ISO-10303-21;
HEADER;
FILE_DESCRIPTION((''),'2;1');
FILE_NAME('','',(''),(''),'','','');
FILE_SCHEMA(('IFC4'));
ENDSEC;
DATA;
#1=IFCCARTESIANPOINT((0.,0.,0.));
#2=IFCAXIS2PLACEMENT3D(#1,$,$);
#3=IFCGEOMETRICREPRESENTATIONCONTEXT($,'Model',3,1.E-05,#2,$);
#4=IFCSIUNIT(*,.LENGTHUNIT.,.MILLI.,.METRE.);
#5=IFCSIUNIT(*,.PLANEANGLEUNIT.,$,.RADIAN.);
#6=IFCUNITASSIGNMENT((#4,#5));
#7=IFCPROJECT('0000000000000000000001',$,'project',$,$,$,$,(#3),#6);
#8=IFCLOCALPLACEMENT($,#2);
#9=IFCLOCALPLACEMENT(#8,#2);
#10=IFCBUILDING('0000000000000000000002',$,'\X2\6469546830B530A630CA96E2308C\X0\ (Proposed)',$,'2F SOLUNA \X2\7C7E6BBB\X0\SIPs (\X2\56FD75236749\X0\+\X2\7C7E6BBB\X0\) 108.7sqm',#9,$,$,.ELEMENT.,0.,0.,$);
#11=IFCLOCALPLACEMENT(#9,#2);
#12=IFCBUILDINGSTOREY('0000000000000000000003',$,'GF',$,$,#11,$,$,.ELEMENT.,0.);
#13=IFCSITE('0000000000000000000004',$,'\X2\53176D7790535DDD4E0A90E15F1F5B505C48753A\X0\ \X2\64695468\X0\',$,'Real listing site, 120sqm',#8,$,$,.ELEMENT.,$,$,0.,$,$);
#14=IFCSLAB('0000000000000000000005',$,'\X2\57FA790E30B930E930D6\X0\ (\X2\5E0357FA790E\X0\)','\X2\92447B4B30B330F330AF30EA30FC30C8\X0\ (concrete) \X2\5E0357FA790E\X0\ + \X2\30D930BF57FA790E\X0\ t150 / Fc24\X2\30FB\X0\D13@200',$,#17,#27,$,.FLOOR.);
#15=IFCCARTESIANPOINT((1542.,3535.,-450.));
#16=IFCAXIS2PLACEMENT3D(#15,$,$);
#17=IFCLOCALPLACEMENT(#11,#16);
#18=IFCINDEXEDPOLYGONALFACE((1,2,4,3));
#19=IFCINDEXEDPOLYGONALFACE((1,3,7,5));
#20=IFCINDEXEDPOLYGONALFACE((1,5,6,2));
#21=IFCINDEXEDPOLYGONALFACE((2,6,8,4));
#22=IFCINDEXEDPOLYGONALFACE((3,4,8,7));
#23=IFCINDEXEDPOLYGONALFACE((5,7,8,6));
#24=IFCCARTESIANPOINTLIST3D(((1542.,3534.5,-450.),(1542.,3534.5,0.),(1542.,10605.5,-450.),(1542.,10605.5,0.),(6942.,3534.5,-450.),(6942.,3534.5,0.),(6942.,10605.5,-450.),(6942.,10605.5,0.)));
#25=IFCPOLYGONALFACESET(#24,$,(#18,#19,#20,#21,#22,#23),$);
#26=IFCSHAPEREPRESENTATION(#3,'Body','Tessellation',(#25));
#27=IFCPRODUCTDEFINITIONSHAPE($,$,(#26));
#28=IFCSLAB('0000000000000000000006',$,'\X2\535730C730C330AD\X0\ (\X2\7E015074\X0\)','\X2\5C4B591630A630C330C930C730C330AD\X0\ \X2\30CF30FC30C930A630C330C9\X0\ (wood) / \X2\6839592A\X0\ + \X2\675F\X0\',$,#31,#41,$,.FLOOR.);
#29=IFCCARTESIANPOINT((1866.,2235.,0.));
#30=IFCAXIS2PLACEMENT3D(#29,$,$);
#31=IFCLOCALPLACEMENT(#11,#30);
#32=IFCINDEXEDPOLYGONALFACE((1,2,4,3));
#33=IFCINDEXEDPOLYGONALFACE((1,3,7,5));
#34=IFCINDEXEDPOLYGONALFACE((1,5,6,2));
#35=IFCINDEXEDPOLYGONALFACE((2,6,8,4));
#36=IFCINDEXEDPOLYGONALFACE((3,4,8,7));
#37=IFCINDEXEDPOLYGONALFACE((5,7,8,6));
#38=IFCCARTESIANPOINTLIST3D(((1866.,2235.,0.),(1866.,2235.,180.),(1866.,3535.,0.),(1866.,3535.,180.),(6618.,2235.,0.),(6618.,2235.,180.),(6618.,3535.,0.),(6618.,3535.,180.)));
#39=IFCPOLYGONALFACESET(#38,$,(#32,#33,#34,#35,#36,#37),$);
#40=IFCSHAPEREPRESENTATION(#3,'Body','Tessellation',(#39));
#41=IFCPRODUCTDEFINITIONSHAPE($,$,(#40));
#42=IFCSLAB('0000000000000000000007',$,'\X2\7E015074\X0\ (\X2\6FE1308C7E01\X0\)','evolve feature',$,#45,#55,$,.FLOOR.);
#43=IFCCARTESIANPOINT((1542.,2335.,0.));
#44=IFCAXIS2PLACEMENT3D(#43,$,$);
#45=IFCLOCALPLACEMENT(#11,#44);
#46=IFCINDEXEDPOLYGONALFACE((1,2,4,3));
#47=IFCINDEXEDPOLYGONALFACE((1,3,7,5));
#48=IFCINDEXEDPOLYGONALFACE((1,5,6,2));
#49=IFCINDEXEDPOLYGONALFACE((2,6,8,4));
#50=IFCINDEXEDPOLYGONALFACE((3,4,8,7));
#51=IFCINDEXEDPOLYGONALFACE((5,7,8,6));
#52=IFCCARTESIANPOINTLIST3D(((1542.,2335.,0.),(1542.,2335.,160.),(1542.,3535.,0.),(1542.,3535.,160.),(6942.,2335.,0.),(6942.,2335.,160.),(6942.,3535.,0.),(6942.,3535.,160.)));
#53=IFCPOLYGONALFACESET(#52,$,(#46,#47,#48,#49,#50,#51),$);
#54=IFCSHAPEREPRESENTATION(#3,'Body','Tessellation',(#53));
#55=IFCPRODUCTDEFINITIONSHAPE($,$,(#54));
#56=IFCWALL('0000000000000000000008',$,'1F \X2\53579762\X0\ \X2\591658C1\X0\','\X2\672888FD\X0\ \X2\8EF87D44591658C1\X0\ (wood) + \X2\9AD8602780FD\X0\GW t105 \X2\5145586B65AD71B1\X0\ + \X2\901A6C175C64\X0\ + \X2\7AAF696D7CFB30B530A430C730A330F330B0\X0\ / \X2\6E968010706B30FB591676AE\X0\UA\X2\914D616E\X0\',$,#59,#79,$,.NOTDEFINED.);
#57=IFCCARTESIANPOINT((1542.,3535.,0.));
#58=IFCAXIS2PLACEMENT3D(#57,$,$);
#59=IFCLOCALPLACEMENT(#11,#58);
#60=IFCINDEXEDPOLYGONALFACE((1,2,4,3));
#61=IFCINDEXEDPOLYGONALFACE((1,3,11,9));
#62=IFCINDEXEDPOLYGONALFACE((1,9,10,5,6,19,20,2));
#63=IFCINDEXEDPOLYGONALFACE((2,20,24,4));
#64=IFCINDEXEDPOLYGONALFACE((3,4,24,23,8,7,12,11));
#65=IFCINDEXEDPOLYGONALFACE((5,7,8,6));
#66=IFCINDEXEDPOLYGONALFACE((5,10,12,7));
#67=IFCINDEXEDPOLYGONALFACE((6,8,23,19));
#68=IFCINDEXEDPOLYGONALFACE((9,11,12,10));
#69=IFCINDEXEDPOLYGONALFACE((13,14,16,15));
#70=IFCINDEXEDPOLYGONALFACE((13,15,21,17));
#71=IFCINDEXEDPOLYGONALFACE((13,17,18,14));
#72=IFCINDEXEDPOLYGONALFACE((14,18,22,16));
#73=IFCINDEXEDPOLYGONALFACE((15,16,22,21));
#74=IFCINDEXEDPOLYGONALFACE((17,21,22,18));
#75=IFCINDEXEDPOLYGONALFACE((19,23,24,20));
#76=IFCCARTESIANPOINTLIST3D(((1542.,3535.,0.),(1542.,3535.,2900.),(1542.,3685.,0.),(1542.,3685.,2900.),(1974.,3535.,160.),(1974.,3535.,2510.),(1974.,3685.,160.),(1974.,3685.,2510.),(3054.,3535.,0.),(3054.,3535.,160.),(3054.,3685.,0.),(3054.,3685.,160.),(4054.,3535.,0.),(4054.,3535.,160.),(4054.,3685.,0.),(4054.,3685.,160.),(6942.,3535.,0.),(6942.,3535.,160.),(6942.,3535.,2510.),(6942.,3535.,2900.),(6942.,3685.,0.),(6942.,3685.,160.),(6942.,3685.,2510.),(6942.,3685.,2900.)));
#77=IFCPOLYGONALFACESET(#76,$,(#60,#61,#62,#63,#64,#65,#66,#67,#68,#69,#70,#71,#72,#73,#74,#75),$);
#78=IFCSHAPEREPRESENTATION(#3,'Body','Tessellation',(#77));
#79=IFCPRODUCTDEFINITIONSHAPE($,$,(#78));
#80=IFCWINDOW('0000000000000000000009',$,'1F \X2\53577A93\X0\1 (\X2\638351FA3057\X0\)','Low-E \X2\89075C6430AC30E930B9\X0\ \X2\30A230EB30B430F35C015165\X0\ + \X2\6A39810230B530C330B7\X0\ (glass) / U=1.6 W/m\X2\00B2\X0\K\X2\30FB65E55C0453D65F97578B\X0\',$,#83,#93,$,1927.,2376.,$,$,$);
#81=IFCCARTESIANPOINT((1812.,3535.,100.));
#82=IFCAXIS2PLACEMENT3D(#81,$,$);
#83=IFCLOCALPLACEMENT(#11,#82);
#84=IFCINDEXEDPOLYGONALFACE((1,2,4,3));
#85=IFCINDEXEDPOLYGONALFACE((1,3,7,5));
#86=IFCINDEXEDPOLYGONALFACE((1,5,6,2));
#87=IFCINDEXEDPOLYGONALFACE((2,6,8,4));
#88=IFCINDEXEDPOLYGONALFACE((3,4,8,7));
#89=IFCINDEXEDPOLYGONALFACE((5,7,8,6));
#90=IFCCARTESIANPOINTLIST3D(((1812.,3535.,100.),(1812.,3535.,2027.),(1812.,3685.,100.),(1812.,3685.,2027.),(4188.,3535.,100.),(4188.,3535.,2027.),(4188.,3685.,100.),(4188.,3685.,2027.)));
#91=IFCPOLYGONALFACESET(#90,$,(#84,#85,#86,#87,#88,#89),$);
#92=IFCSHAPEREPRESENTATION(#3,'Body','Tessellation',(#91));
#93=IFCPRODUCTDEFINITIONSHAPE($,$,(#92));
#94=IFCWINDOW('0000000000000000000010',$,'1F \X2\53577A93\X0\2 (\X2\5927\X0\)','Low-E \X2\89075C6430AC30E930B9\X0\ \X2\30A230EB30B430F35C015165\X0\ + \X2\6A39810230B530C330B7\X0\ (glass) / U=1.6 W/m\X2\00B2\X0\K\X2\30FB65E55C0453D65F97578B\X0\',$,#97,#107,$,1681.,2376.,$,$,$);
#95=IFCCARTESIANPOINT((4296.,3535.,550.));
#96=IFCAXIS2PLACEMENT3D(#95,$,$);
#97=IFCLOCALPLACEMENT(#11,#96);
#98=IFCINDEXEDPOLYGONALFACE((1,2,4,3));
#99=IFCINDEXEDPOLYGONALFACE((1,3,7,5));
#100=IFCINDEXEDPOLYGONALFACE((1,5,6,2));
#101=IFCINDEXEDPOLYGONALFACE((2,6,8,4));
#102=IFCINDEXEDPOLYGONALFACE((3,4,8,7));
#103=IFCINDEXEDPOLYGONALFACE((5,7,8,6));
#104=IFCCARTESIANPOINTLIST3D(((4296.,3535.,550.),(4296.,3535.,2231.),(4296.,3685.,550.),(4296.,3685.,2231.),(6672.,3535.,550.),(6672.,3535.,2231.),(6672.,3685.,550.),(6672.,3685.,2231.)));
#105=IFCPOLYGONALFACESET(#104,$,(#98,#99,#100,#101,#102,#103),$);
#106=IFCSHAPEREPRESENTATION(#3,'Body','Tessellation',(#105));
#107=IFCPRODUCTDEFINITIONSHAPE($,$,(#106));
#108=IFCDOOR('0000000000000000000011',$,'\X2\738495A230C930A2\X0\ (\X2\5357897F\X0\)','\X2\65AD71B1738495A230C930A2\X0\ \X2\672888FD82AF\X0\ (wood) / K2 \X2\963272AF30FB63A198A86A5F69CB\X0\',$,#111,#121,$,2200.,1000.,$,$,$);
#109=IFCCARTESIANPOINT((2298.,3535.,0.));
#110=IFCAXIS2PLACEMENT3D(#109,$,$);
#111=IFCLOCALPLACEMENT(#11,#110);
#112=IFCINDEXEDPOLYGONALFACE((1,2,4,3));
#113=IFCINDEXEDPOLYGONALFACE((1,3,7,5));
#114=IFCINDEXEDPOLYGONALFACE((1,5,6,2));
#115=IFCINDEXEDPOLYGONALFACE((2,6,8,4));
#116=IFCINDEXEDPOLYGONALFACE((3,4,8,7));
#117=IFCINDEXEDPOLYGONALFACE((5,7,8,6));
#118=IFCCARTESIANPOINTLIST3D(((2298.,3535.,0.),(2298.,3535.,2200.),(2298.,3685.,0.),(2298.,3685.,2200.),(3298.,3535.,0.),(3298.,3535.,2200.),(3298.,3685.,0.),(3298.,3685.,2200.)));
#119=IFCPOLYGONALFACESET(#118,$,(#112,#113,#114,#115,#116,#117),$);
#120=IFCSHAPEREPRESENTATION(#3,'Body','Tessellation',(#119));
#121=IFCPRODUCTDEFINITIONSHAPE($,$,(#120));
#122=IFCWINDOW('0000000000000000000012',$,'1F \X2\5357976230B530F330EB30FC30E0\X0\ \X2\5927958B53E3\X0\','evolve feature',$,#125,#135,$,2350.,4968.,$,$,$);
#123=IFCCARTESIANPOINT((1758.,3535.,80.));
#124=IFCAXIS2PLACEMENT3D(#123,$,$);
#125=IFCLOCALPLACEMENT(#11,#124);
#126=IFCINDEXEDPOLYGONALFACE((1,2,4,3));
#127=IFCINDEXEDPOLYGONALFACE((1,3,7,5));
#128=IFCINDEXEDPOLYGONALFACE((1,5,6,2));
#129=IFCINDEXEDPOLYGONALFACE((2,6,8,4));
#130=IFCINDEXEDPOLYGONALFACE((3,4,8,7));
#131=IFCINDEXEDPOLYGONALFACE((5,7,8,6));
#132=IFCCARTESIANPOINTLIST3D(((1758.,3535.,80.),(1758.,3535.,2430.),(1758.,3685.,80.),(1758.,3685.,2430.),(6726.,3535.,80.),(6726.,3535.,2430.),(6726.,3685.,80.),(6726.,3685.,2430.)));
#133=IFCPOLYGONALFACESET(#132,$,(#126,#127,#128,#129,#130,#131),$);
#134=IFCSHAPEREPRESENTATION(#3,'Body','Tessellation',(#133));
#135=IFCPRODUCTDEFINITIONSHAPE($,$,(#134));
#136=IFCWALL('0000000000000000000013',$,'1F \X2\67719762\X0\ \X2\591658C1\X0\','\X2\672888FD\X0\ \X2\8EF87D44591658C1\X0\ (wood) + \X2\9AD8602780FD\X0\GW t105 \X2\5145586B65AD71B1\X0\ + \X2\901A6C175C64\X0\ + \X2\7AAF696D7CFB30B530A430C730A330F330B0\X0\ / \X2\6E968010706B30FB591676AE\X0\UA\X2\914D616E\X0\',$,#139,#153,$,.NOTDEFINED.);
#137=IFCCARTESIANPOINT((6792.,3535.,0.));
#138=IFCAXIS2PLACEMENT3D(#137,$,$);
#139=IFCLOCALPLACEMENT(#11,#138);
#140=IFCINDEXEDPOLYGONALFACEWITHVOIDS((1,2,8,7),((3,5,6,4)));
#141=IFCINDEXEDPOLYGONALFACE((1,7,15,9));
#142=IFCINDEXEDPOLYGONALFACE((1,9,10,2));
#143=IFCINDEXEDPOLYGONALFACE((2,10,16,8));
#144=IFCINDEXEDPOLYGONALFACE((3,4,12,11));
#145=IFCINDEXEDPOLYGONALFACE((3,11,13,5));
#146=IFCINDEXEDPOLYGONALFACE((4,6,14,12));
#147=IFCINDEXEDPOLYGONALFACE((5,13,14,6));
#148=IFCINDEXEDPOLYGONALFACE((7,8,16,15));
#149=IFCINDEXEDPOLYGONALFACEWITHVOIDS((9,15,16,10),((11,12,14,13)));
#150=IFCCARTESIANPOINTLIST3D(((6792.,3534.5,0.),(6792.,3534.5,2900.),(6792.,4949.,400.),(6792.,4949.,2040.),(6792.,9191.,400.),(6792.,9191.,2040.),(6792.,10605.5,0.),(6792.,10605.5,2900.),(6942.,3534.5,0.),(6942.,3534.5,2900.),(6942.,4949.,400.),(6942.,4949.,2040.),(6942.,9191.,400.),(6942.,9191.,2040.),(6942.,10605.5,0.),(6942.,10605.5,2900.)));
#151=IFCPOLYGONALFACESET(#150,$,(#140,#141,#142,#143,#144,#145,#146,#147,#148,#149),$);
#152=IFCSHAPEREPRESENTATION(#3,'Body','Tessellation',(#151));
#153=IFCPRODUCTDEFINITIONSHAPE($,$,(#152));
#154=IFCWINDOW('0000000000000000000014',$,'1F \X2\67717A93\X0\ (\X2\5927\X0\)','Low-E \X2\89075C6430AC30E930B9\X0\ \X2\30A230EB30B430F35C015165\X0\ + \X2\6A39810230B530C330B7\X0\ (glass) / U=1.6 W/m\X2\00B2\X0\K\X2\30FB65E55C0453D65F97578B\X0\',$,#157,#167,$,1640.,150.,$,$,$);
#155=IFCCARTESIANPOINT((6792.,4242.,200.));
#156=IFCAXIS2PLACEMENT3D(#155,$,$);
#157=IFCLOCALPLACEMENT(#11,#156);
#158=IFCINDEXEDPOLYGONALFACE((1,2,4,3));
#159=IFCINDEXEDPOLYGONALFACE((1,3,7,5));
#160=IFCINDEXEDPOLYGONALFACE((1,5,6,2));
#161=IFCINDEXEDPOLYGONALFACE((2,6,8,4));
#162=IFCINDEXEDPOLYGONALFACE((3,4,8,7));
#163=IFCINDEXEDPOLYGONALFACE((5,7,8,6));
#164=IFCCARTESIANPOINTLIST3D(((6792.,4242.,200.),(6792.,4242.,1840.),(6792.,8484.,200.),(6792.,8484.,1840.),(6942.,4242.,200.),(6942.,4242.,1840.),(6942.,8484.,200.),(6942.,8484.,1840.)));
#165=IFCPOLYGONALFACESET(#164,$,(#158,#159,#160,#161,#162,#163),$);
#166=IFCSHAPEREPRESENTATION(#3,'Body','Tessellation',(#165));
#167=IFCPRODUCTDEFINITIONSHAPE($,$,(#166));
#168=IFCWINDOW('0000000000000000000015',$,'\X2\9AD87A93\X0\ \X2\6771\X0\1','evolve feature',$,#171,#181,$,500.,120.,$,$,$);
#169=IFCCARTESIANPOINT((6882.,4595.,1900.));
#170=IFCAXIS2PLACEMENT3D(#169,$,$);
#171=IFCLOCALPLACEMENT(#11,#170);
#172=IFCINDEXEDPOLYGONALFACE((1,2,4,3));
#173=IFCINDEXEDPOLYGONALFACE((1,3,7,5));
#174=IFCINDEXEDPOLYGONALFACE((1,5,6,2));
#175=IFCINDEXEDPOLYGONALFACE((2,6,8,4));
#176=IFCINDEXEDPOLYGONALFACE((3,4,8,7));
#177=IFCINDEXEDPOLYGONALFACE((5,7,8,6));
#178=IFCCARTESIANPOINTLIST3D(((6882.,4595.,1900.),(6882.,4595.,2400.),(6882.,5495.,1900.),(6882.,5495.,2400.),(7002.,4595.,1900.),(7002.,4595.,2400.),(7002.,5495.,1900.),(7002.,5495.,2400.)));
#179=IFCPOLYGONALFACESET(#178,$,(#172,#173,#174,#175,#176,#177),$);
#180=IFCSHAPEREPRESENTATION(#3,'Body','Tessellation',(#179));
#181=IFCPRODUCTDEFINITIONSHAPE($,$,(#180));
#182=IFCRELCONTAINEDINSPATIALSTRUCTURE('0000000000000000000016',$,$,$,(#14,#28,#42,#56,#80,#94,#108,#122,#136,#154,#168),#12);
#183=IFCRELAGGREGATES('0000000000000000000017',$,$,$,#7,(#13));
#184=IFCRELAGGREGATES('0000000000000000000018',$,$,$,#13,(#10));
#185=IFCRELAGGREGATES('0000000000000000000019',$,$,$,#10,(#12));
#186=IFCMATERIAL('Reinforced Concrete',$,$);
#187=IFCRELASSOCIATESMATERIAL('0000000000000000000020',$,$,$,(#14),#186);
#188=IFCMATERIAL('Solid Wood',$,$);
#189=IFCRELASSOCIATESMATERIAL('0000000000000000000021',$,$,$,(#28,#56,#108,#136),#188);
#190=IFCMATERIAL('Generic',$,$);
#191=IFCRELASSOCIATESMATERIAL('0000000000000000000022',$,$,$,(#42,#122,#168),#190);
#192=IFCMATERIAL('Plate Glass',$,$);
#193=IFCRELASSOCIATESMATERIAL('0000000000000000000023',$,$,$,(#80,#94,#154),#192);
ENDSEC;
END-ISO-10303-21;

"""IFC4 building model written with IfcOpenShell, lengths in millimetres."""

from ifc_helpers import new_model, si_unit, frame, frame_2d, origin, place, context, project, spatial, rectangle, extrude, material, element, fill, save


model = new_model("IFC4")

# Units and contexts
model_context = context("Model", 3, precision=1e-05, world=origin())
ifc_project = project(units=[si_unit("LENGTHUNIT", "METRE", prefix="MILLI"), si_unit("PLANEANGLEUNIT", "RADIAN")], contexts=[model_context])

# Site, building, storey
site_placement = place(None, origin())
site = spatial("IfcSite", under=ifc_project, at=site_placement, Name="北海道川上郡弟子屈町 摩周", ObjectType="Real listing site, 120sqm", CompositionType="ELEMENT", RefElevation=0.0)
building_placement = place(site_placement, origin())
building = spatial("IfcBuilding", under=site, at=building_placement, Name="摩周サウナ離れ (Proposed)", ObjectType="2F SOLUNA 籾殻SIPs (国産杉+籾殻) 108.7sqm", CompositionType="ELEMENT", ElevationOfRefHeight=0.0, ElevationOfTerrain=0.0)
storey_placement = place(building_placement, origin())
storey = spatial("IfcBuildingStorey", under=building, at=storey_placement, Name="GF", CompositionType="ELEMENT", Elevation=0.0)

# Slabs
ifc_material_1 = material(Name="Reinforced Concrete")
slab_1_placement = place(storey_placement, frame((1542.0, 3535.0, -450.0)))
element("IfcSlab", 1, at=slab_1_placement, inside=storey, material=ifc_material_1, Name="基礎スラブ (布基礎)", Description="鉄筋コンクリート (concrete) 布基礎 + ベタ基礎 t150 / Fc24・D13@200", PredefinedType="FLOOR", context=model_context, shape_type="SweptSolid", body=[
    extrude(rectangle(XDim=5400.0, YDim=7071.0, at=frame_2d((2700.0, 3535.0))), frame((1542.0, 3535.0, -450.0)), (0.0, 0.0, 1.0), 450.0),
])
ifc_material_2 = material(Name="Solid Wood")
slab_2_placement = place(storey_placement, frame((1866.0, 2235.0, 0.0)))
element("IfcSlab", 2, at=slab_2_placement, inside=storey, material=ifc_material_2, Name="南デッキ (縁側)", Description="屋外ウッドデッキ ハードウッド (wood) / 根太 + 束", PredefinedType="FLOOR", context=model_context, shape_type="SweptSolid", body=[
    extrude(rectangle(XDim=4752.0, YDim=1300.0, at=frame_2d((2376.0, 650.0))), frame((1866.0, 2235.0, 0.0)), (0.0, 0.0, 1.0), 180.0),
])
ifc_material_3 = material(Name="Generic")
slab_3_placement = place(storey_placement, frame((1542.0, 2335.0, 0.0)))
element("IfcSlab", 3, at=slab_3_placement, inside=storey, material=ifc_material_3, Name="縁側 (濡れ縁)", Description="evolve feature", PredefinedType="FLOOR", context=model_context, shape_type="SweptSolid", body=[
    extrude(rectangle(XDim=5400.0, YDim=1200.0, at=frame_2d((2700.0, 600.0))), frame((1542.0, 2335.0, 0.0)), (0.0, 0.0, 1.0), 160.0),
])

# Wall, openings, windows, door
wall_1_placement = place(storey_placement, frame((1542.0, 3535.0, 0.0)))
wall_1 = element("IfcWall", 4, at=wall_1_placement, inside=storey, material=ifc_material_2, Name="1F 南面 外壁", Description="木製 軸組外壁 (wood) + 高性能GW t105 充填断熱 + 通気層 + 窯業系サイディング / 準耐火・外皮UA配慮", PredefinedType="NOTDEFINED", context=model_context, shape_type="SweptSolid", body=[
    extrude(rectangle(XDim=5400.0, YDim=150.0, at=frame_2d((2700.0, 75.0))), frame((1542.0, 3535.0, 0.0)), (0.0, 0.0, 1.0), 2900.0),
])
opening_1_placement = place(storey_placement, frame((1812.0, 3535.0, 100.0)))
opening_1 = element("IfcOpeningElement", 5, at=opening_1_placement, cuts=wall_1, PredefinedType="NOTDEFINED", context=model_context, shape_type="SweptSolid", body=[
    extrude(rectangle(XDim=2376.0, YDim=150.0, at=frame_2d((1188.0, 75.0))), frame((1812.0, 3535.0, 100.0)), (0.0, 0.0, 1.0), 1927.0),
])
opening_2_placement = place(storey_placement, frame((4296.0, 3535.0, 550.0)))
opening_2 = element("IfcOpeningElement", 6, at=opening_2_placement, cuts=wall_1, PredefinedType="NOTDEFINED", context=model_context, shape_type="SweptSolid", body=[
    extrude(rectangle(XDim=2376.0, YDim=150.0, at=frame_2d((1188.0, 75.0))), frame((4296.0, 3535.0, 550.0)), (0.0, 0.0, 1.0), 1681.0),
])
opening_3_placement = place(storey_placement, frame((2298.0, 3535.0, 0.0)))
opening_3 = element("IfcOpeningElement", 7, at=opening_3_placement, cuts=wall_1, PredefinedType="NOTDEFINED", context=model_context, shape_type="SweptSolid", body=[
    extrude(rectangle(XDim=1000.0, YDim=150.0, at=frame_2d((500.0, 75.0))), frame((2298.0, 3535.0, 0.0)), (0.0, 0.0, 1.0), 2200.0),
])
opening_4_placement = place(storey_placement, frame((1758.0, 3535.0, 80.0)))
opening_4 = element("IfcOpeningElement", 8, at=opening_4_placement, cuts=wall_1, PredefinedType="NOTDEFINED", context=model_context, shape_type="SweptSolid", body=[
    extrude(rectangle(XDim=4968.0, YDim=150.0, at=frame_2d((2484.0, 75.0))), frame((1758.0, 3535.0, 80.0)), (0.0, 0.0, 1.0), 2350.0),
])
ifc_material_4 = material(Name="Plate Glass")
window_1_placement = place(storey_placement, frame((1812.0, 3535.0, 100.0)))
window_1 = element("IfcWindow", 9, at=window_1_placement, inside=storey, material=ifc_material_4, Name="1F 南窓1 (掃出し)", Description="Low-E 複層ガラス アルゴン封入 + 樹脂サッシ (glass) / U=1.6 W/m²K・日射取得型", OverallHeight=1927.0, OverallWidth=2376.0, context=model_context, shape_type="SweptSolid", body=[
    extrude(rectangle(XDim=2376.0, YDim=150.0, at=frame_2d((1188.0, 75.0))), frame((1812.0, 3535.0, 100.0)), (0.0, 0.0, 1.0), 1927.0),
])
fill(opening_1, window_1)
window_2_placement = place(storey_placement, frame((4296.0, 3535.0, 550.0)))
window_2 = element("IfcWindow", 10, at=window_2_placement, inside=storey, material=ifc_material_4, Name="1F 南窓2 (大)", Description="Low-E 複層ガラス アルゴン封入 + 樹脂サッシ (glass) / U=1.6 W/m²K・日射取得型", OverallHeight=1681.0, OverallWidth=2376.0, context=model_context, shape_type="SweptSolid", body=[
    extrude(rectangle(XDim=2376.0, YDim=150.0, at=frame_2d((1188.0, 75.0))), frame((4296.0, 3535.0, 550.0)), (0.0, 0.0, 1.0), 1681.0),
])
fill(opening_2, window_2)
door_placement = place(storey_placement, frame((2298.0, 3535.0, 0.0)))
door = element("IfcDoor", 11, at=door_placement, inside=storey, material=ifc_material_2, Name="玄関ドア (南西)", Description="断熱玄関ドア 木製芯 (wood) / K2 防犯・採風機構", OverallHeight=2200.0, OverallWidth=1000.0, context=model_context, shape_type="SweptSolid", body=[
    extrude(rectangle(XDim=1000.0, YDim=150.0, at=frame_2d((500.0, 75.0))), frame((2298.0, 3535.0, 0.0)), (0.0, 0.0, 1.0), 2200.0),
])
fill(opening_3, door)
window_3_placement = place(storey_placement, frame((1758.0, 3535.0, 80.0)))
window_3 = element("IfcWindow", 12, at=window_3_placement, inside=storey, material=ifc_material_3, Name="1F 南面サンルーム 大開口", Description="evolve feature", OverallHeight=2350.0, OverallWidth=4968.0, context=model_context, shape_type="SweptSolid", body=[
    extrude(rectangle(XDim=4968.0, YDim=150.0, at=frame_2d((2484.0, 75.0))), frame((1758.0, 3535.0, 80.0)), (0.0, 0.0, 1.0), 2350.0),
])
fill(opening_4, window_3)

# Wall, openings, windows
wall_2_placement = place(storey_placement, frame((6792.0, 3535.0, 0.0)))
wall_2 = element("IfcWall", 13, at=wall_2_placement, inside=storey, material=ifc_material_2, Name="1F 東面 外壁", Description="木製 軸組外壁 (wood) + 高性能GW t105 充填断熱 + 通気層 + 窯業系サイディング / 準耐火・外皮UA配慮", PredefinedType="NOTDEFINED", context=model_context, shape_type="SweptSolid", body=[
    extrude(rectangle(XDim=150.0, YDim=7071.0, at=frame_2d((75.0, 3535.0))), frame((6792.0, 3535.0, 0.0)), (0.0, 0.0, 1.0), 2900.0),
])
opening_5_placement = place(storey_placement, frame((6792.0, 4242.0, 200.0)))
opening_5 = element("IfcOpeningElement", 14, at=opening_5_placement, cuts=wall_2, PredefinedType="NOTDEFINED", context=model_context, shape_type="SweptSolid", body=[
    extrude(rectangle(XDim=150.0, YDim=4242.0, at=frame_2d((75.0, 2121.0))), frame((6792.0, 4242.0, 200.0)), (0.0, 0.0, 1.0), 1640.0),
])
opening_6_placement = place(storey_placement, frame((6882.0, 4595.0, 1900.0)))
opening_6 = element("IfcOpeningElement", 15, at=opening_6_placement, cuts=wall_2, PredefinedType="NOTDEFINED", context=model_context, shape_type="SweptSolid", body=[
    extrude(rectangle(XDim=120.0, YDim=900.0, at=frame_2d((60.0, 450.0))), frame((6882.0, 4595.0, 1900.0)), (0.0, 0.0, 1.0), 500.0),
])
window_4_placement = place(storey_placement, frame((6792.0, 4242.0, 200.0)))
window_4 = element("IfcWindow", 16, at=window_4_placement, inside=storey, material=ifc_material_4, Name="1F 東窓 (大)", Description="Low-E 複層ガラス アルゴン封入 + 樹脂サッシ (glass) / U=1.6 W/m²K・日射取得型", OverallHeight=1640.0, OverallWidth=150.0, context=model_context, shape_type="SweptSolid", body=[
    extrude(rectangle(XDim=150.0, YDim=4242.0, at=frame_2d((75.0, 2121.0))), frame((6792.0, 4242.0, 200.0)), (0.0, 0.0, 1.0), 1640.0),
])
fill(opening_5, window_4)
window_5_placement = place(storey_placement, frame((6882.0, 4595.0, 1900.0)))
window_5 = element("IfcWindow", 17, at=window_5_placement, inside=storey, material=ifc_material_3, Name="高窓 東1", Description="evolve feature", OverallHeight=500.0, OverallWidth=120.0, context=model_context, shape_type="SweptSolid", body=[
    extrude(rectangle(XDim=120.0, YDim=900.0, at=frame_2d((60.0, 450.0))), frame((6882.0, 4595.0, 1900.0)), (0.0, 0.0, 1.0), 500.0),
])
fill(opening_6, window_5)

save(model, "model.ifc")
